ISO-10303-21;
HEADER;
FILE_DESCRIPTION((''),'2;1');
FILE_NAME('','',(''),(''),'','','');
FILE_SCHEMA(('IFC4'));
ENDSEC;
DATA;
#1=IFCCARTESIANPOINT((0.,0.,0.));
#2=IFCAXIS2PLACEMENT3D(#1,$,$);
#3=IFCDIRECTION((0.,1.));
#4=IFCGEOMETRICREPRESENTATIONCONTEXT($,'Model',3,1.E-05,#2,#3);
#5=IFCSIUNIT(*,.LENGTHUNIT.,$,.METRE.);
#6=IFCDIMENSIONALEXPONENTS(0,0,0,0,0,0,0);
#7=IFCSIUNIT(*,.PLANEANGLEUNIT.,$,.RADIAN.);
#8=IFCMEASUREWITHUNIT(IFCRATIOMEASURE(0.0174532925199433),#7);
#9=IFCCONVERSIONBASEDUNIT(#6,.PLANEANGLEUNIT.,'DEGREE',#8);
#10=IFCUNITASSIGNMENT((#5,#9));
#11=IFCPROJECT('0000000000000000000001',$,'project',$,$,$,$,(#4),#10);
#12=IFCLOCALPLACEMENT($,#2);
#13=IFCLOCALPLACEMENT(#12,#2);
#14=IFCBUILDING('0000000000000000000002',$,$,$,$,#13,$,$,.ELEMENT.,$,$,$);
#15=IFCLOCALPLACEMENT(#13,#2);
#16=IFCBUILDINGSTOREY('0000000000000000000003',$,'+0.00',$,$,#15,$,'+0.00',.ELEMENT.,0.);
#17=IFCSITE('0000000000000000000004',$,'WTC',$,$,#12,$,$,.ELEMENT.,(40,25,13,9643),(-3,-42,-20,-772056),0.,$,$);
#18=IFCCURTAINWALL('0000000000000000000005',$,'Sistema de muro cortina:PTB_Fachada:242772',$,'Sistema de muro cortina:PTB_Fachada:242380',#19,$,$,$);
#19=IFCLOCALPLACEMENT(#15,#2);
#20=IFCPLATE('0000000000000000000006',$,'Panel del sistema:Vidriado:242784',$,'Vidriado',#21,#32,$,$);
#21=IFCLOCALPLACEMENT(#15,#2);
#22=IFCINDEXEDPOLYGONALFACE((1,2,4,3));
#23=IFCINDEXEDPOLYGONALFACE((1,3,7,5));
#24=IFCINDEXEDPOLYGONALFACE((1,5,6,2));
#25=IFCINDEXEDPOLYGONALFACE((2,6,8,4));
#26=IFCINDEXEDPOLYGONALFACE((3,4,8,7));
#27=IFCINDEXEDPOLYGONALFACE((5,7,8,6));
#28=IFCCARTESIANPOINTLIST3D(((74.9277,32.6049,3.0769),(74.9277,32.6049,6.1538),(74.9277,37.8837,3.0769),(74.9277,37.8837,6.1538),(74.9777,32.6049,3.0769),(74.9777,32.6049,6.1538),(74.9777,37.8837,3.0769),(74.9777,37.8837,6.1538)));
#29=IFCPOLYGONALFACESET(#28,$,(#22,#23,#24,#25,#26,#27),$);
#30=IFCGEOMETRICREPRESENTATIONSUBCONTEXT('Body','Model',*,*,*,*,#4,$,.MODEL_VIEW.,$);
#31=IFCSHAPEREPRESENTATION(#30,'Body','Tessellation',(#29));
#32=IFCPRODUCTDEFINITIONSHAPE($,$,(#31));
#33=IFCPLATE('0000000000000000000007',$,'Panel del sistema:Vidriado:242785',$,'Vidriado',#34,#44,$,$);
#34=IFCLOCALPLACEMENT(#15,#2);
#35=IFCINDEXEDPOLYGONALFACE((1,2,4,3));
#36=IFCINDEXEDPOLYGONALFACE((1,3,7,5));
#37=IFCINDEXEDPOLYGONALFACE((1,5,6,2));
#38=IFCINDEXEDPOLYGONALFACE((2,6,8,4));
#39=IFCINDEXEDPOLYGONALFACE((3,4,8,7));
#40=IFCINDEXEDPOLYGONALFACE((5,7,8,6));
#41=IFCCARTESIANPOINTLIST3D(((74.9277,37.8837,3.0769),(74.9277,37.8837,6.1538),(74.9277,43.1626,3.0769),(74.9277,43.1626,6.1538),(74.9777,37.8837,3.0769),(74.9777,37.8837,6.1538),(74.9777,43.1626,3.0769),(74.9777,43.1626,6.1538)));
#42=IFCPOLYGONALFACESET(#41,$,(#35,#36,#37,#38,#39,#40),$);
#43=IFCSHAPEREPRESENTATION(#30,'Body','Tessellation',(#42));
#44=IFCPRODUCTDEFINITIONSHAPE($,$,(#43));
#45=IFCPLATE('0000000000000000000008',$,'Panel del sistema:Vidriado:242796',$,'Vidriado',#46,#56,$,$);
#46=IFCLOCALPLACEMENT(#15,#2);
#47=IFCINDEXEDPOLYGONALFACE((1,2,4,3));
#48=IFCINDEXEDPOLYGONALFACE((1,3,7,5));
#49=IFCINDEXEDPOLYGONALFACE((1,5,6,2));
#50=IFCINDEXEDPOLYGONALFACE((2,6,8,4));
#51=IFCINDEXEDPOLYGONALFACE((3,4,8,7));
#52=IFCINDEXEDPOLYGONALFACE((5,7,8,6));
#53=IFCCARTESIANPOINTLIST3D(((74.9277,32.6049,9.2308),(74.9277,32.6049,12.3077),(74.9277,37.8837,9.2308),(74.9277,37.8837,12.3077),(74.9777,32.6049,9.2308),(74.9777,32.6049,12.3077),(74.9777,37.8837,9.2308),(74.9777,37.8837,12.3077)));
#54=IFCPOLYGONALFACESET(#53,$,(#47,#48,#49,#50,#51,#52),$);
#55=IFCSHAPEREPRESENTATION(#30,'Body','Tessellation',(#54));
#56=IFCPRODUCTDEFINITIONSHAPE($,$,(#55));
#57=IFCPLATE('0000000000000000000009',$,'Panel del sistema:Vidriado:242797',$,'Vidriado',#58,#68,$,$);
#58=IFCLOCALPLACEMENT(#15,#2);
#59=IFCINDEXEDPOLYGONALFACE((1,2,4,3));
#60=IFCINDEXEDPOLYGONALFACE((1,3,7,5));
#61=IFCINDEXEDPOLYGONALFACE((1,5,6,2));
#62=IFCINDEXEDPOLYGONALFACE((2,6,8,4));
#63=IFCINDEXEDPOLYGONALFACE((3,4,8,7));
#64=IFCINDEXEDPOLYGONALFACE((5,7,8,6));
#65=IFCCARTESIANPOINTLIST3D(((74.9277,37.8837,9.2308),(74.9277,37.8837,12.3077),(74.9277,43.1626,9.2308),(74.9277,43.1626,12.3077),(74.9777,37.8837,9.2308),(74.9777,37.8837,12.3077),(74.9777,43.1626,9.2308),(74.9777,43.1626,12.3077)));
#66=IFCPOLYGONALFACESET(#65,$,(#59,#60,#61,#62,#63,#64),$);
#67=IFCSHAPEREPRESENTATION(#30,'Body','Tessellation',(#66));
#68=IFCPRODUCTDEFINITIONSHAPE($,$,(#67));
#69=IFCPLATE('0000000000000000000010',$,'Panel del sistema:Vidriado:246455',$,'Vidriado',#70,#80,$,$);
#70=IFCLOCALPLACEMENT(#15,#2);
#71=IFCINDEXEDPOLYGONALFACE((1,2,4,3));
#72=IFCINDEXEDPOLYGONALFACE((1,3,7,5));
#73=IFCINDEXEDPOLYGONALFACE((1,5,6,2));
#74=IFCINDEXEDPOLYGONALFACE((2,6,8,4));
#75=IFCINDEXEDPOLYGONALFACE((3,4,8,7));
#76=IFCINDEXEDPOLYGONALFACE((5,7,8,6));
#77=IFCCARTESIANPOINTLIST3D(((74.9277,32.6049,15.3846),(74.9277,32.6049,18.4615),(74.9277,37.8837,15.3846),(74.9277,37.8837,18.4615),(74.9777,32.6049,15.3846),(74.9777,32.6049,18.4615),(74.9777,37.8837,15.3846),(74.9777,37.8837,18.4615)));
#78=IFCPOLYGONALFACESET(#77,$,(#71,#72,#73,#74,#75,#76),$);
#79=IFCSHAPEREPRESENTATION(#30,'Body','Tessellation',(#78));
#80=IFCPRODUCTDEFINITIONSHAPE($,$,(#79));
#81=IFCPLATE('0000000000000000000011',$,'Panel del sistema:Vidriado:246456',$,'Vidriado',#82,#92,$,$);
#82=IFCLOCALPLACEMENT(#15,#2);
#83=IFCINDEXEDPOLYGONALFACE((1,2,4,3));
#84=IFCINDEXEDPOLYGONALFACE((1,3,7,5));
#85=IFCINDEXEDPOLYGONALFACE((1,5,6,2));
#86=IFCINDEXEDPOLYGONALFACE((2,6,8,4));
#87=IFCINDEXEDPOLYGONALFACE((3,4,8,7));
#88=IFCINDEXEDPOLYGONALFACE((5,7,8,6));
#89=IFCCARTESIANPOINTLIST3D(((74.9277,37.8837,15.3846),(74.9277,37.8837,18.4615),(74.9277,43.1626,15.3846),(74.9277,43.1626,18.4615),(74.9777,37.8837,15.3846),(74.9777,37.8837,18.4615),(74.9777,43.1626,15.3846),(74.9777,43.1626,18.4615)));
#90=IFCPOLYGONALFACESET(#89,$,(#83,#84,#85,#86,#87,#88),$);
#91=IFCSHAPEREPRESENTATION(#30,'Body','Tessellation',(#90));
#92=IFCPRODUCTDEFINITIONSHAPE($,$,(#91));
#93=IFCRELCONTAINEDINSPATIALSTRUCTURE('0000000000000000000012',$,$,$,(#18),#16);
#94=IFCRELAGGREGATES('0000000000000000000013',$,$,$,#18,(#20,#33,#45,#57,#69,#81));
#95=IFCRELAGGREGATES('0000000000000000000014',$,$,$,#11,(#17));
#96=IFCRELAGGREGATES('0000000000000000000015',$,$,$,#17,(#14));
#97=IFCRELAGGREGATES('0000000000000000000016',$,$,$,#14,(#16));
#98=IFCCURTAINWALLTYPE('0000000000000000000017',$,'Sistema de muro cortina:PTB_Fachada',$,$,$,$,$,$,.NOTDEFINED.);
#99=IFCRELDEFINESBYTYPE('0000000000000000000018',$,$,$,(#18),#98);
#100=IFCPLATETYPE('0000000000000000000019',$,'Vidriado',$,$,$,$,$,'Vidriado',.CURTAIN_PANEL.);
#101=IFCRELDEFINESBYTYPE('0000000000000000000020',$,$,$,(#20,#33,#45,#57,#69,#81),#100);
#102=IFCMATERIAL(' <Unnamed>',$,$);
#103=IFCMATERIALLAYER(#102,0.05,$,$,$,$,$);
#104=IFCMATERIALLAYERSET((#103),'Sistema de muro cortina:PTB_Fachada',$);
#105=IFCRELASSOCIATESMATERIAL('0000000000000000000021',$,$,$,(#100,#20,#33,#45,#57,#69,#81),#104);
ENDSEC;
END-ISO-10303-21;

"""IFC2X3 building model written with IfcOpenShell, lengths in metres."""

from ifc_helpers import new_model, entity, si_unit, converted_unit, direction, frame, origin, origin_2d_with_axis, place, context, subcontext, project, spatial, rectangle, extrude, source, transform, mapped, material, layer, layer_set, layer_usage, type_object, type_shapes, element, aggregate, save


model = new_model("IFC2X3")

# Units and contexts
model_context = context("Model", 3, precision=1e-05, world=origin(), true_north=direction((0.0, 1.0)))
body_context = subcontext(model_context, "Body", "Model", "MODEL_VIEW")
ifc_project = project(units=[si_unit("LENGTHUNIT", "METRE"), converted_unit("PLANEANGLEUNIT", "DEGREE", entity("IfcRatioMeasure", 0.0174532925199433), si_unit("PLANEANGLEUNIT", "RADIAN"), dimensions=[0, 0, 0, 0, 0, 0, 0])], contexts=[model_context])

# Site, building, storey
site_placement = place(None, origin())
site = spatial("IfcSite", under=ifc_project, at=site_placement, Name="WTC", CompositionType="ELEMENT", RefLatitude=(40, 25, 13, 9643), RefLongitude=(-3, -42, -20, -772056), RefElevation=0.0)
building_placement = place(site_placement, origin())
building = spatial("IfcBuilding", under=site, at=building_placement, CompositionType="ELEMENT")
storey_placement = place(building_placement, origin())
storey = spatial("IfcBuildingStorey", under=building, at=storey_placement, Name="+0.00", LongName="+0.00", CompositionType="ELEMENT", Elevation=0.0)

# Curtain wall, plates
curtain_wall_type = type_object("IfcCurtainWallType", Name="Sistema de muro cortina:PTB_Fachada", PredefinedType="NOTDEFINED")
ifc_material = material(Name=" <Unnamed>")
ifc_layer_1 = layer(ifc_material, 0.05)
ifc_layer_set_1 = layer_set([ifc_layer_1], Name="Sistema de muro cortina:PTB_Fachada")
curtain_wall_1_placement = place(storey_placement, origin())
curtain_wall_1 = element("IfcCurtainWall", 1, at=curtain_wall_1_placement, inside=storey, type_object=curtain_wall_type, Name="Sistema de muro cortina:PTB_Fachada:242772", ObjectType="Sistema de muro cortina:PTB_Fachada:242380")
ifc_layer_usage_1 = layer_usage(ifc_layer_set_1, "AXIS3", "POSITIVE", 0.0)
plate_type_1 = type_object("IfcPlateType", Name="Vidriado", ElementType="Vidriado", PredefinedType="CURTAIN_PANEL", material=ifc_layer_set_1)
shared_shape_1 = source(origin(), body_context, "Body", "SweptSolid", [
    extrude(rectangle(XDim=0.05, YDim=5.2789, at=origin_2d_with_axis()), frame((0.0, 0.0, 0.0), z_axis=(0.0, 0.0, 1.0), x_axis=(0.0, 1.0, 0.0)), (0.0, 0.0, 1.0), 3.0769),
])
type_shapes(plate_type_1, [shared_shape_1])
plate_1_placement = place(curtain_wall_1_placement, frame((74.9527, 35.2443, 3.0769), z_axis=(0.0, 0.0, 1.0), x_axis=(0.0, 1.0, 0.0)))
plate_1 = element("IfcPlate", 2, at=plate_1_placement, type_object=plate_type_1, material=ifc_layer_usage_1, Name="Panel del sistema:Vidriado:242784", ObjectType="Vidriado", context=body_context, shape_type="MappedRepresentation", body=[
    mapped(shared_shape_1, transform((0.0, 0.0, 0.0), scale=1.0)),
])
ifc_layer_usage_2 = layer_usage(ifc_layer_set_1, "AXIS3", "POSITIVE", 0.0)
plate_2_placement = place(curtain_wall_1_placement, frame((74.9527, 40.5232, 3.0769), z_axis=(0.0, 0.0, 1.0), x_axis=(0.0, 1.0, 0.0)))
plate_2 = element("IfcPlate", 3, at=plate_2_placement, type_object=plate_type_1, material=ifc_layer_usage_2, Name="Panel del sistema:Vidriado:242785", ObjectType="Vidriado", context=body_context, shape_type="MappedRepresentation", body=[
    mapped(shared_shape_1, transform((0.0, 0.0, 0.0), scale=1.0)),
])
ifc_layer_usage_3 = layer_usage(ifc_layer_set_1, "AXIS3", "POSITIVE", 0.0)
plate_3_placement = place(curtain_wall_1_placement, frame((74.9527, 35.2443, 9.2308), z_axis=(0.0, 0.0, 1.0), x_axis=(0.0, 1.0, 0.0)))
plate_3 = element("IfcPlate", 4, at=plate_3_placement, type_object=plate_type_1, material=ifc_layer_usage_3, Name="Panel del sistema:Vidriado:242796", ObjectType="Vidriado", context=body_context, shape_type="MappedRepresentation", body=[
    mapped(shared_shape_1, transform((0.0, 0.0, 0.0), scale=1.0)),
])
ifc_layer_usage_4 = layer_usage(ifc_layer_set_1, "AXIS3", "POSITIVE", 0.0)
plate_4_placement = place(curtain_wall_1_placement, frame((74.9527, 40.5232, 9.2308), z_axis=(0.0, 0.0, 1.0), x_axis=(0.0, 1.0, 0.0)))
plate_4 = element("IfcPlate", 5, at=plate_4_placement, type_object=plate_type_1, material=ifc_layer_usage_4, Name="Panel del sistema:Vidriado:242797", ObjectType="Vidriado", context=body_context, shape_type="MappedRepresentation", body=[
    mapped(shared_shape_1, transform((0.0, 0.0, 0.0), scale=1.0)),
])
ifc_layer_usage_5 = layer_usage(ifc_layer_set_1, "AXIS3", "POSITIVE", 0.0)
plate_5_placement = place(curtain_wall_1_placement, frame((74.9527, 35.2443, 15.3846), z_axis=(0.0, 0.0, 1.0), x_axis=(0.0, 1.0, 0.0)))
plate_5 = element("IfcPlate", 6, at=plate_5_placement, type_object=plate_type_1, material=ifc_layer_usage_5, Name="Panel del sistema:Vidriado:246455", ObjectType="Vidriado", context=body_context, shape_type="MappedRepresentation", body=[
    mapped(shared_shape_1, transform((0.0, 0.0, 0.0), scale=1.0)),
])
ifc_layer_usage_6 = layer_usage(ifc_layer_set_1, "AXIS3", "POSITIVE", 0.0)
plate_6_placement = place(curtain_wall_1_placement, frame((74.9527, 40.5232, 15.3846), z_axis=(0.0, 0.0, 1.0), x_axis=(0.0, 1.0, 0.0)))
plate_6 = element("IfcPlate", 7, at=plate_6_placement, type_object=plate_type_1, material=ifc_layer_usage_6, Name="Panel del sistema:Vidriado:246456", ObjectType="Vidriado", context=body_context, shape_type="MappedRepresentation", body=[
    mapped(shared_shape_1, transform((0.0, 0.0, 0.0), scale=1.0)),
])
aggregate(curtain_wall_1, [plate_1, plate_2, plate_3, plate_4, plate_5, plate_6])

save(model, "model.ifc")
